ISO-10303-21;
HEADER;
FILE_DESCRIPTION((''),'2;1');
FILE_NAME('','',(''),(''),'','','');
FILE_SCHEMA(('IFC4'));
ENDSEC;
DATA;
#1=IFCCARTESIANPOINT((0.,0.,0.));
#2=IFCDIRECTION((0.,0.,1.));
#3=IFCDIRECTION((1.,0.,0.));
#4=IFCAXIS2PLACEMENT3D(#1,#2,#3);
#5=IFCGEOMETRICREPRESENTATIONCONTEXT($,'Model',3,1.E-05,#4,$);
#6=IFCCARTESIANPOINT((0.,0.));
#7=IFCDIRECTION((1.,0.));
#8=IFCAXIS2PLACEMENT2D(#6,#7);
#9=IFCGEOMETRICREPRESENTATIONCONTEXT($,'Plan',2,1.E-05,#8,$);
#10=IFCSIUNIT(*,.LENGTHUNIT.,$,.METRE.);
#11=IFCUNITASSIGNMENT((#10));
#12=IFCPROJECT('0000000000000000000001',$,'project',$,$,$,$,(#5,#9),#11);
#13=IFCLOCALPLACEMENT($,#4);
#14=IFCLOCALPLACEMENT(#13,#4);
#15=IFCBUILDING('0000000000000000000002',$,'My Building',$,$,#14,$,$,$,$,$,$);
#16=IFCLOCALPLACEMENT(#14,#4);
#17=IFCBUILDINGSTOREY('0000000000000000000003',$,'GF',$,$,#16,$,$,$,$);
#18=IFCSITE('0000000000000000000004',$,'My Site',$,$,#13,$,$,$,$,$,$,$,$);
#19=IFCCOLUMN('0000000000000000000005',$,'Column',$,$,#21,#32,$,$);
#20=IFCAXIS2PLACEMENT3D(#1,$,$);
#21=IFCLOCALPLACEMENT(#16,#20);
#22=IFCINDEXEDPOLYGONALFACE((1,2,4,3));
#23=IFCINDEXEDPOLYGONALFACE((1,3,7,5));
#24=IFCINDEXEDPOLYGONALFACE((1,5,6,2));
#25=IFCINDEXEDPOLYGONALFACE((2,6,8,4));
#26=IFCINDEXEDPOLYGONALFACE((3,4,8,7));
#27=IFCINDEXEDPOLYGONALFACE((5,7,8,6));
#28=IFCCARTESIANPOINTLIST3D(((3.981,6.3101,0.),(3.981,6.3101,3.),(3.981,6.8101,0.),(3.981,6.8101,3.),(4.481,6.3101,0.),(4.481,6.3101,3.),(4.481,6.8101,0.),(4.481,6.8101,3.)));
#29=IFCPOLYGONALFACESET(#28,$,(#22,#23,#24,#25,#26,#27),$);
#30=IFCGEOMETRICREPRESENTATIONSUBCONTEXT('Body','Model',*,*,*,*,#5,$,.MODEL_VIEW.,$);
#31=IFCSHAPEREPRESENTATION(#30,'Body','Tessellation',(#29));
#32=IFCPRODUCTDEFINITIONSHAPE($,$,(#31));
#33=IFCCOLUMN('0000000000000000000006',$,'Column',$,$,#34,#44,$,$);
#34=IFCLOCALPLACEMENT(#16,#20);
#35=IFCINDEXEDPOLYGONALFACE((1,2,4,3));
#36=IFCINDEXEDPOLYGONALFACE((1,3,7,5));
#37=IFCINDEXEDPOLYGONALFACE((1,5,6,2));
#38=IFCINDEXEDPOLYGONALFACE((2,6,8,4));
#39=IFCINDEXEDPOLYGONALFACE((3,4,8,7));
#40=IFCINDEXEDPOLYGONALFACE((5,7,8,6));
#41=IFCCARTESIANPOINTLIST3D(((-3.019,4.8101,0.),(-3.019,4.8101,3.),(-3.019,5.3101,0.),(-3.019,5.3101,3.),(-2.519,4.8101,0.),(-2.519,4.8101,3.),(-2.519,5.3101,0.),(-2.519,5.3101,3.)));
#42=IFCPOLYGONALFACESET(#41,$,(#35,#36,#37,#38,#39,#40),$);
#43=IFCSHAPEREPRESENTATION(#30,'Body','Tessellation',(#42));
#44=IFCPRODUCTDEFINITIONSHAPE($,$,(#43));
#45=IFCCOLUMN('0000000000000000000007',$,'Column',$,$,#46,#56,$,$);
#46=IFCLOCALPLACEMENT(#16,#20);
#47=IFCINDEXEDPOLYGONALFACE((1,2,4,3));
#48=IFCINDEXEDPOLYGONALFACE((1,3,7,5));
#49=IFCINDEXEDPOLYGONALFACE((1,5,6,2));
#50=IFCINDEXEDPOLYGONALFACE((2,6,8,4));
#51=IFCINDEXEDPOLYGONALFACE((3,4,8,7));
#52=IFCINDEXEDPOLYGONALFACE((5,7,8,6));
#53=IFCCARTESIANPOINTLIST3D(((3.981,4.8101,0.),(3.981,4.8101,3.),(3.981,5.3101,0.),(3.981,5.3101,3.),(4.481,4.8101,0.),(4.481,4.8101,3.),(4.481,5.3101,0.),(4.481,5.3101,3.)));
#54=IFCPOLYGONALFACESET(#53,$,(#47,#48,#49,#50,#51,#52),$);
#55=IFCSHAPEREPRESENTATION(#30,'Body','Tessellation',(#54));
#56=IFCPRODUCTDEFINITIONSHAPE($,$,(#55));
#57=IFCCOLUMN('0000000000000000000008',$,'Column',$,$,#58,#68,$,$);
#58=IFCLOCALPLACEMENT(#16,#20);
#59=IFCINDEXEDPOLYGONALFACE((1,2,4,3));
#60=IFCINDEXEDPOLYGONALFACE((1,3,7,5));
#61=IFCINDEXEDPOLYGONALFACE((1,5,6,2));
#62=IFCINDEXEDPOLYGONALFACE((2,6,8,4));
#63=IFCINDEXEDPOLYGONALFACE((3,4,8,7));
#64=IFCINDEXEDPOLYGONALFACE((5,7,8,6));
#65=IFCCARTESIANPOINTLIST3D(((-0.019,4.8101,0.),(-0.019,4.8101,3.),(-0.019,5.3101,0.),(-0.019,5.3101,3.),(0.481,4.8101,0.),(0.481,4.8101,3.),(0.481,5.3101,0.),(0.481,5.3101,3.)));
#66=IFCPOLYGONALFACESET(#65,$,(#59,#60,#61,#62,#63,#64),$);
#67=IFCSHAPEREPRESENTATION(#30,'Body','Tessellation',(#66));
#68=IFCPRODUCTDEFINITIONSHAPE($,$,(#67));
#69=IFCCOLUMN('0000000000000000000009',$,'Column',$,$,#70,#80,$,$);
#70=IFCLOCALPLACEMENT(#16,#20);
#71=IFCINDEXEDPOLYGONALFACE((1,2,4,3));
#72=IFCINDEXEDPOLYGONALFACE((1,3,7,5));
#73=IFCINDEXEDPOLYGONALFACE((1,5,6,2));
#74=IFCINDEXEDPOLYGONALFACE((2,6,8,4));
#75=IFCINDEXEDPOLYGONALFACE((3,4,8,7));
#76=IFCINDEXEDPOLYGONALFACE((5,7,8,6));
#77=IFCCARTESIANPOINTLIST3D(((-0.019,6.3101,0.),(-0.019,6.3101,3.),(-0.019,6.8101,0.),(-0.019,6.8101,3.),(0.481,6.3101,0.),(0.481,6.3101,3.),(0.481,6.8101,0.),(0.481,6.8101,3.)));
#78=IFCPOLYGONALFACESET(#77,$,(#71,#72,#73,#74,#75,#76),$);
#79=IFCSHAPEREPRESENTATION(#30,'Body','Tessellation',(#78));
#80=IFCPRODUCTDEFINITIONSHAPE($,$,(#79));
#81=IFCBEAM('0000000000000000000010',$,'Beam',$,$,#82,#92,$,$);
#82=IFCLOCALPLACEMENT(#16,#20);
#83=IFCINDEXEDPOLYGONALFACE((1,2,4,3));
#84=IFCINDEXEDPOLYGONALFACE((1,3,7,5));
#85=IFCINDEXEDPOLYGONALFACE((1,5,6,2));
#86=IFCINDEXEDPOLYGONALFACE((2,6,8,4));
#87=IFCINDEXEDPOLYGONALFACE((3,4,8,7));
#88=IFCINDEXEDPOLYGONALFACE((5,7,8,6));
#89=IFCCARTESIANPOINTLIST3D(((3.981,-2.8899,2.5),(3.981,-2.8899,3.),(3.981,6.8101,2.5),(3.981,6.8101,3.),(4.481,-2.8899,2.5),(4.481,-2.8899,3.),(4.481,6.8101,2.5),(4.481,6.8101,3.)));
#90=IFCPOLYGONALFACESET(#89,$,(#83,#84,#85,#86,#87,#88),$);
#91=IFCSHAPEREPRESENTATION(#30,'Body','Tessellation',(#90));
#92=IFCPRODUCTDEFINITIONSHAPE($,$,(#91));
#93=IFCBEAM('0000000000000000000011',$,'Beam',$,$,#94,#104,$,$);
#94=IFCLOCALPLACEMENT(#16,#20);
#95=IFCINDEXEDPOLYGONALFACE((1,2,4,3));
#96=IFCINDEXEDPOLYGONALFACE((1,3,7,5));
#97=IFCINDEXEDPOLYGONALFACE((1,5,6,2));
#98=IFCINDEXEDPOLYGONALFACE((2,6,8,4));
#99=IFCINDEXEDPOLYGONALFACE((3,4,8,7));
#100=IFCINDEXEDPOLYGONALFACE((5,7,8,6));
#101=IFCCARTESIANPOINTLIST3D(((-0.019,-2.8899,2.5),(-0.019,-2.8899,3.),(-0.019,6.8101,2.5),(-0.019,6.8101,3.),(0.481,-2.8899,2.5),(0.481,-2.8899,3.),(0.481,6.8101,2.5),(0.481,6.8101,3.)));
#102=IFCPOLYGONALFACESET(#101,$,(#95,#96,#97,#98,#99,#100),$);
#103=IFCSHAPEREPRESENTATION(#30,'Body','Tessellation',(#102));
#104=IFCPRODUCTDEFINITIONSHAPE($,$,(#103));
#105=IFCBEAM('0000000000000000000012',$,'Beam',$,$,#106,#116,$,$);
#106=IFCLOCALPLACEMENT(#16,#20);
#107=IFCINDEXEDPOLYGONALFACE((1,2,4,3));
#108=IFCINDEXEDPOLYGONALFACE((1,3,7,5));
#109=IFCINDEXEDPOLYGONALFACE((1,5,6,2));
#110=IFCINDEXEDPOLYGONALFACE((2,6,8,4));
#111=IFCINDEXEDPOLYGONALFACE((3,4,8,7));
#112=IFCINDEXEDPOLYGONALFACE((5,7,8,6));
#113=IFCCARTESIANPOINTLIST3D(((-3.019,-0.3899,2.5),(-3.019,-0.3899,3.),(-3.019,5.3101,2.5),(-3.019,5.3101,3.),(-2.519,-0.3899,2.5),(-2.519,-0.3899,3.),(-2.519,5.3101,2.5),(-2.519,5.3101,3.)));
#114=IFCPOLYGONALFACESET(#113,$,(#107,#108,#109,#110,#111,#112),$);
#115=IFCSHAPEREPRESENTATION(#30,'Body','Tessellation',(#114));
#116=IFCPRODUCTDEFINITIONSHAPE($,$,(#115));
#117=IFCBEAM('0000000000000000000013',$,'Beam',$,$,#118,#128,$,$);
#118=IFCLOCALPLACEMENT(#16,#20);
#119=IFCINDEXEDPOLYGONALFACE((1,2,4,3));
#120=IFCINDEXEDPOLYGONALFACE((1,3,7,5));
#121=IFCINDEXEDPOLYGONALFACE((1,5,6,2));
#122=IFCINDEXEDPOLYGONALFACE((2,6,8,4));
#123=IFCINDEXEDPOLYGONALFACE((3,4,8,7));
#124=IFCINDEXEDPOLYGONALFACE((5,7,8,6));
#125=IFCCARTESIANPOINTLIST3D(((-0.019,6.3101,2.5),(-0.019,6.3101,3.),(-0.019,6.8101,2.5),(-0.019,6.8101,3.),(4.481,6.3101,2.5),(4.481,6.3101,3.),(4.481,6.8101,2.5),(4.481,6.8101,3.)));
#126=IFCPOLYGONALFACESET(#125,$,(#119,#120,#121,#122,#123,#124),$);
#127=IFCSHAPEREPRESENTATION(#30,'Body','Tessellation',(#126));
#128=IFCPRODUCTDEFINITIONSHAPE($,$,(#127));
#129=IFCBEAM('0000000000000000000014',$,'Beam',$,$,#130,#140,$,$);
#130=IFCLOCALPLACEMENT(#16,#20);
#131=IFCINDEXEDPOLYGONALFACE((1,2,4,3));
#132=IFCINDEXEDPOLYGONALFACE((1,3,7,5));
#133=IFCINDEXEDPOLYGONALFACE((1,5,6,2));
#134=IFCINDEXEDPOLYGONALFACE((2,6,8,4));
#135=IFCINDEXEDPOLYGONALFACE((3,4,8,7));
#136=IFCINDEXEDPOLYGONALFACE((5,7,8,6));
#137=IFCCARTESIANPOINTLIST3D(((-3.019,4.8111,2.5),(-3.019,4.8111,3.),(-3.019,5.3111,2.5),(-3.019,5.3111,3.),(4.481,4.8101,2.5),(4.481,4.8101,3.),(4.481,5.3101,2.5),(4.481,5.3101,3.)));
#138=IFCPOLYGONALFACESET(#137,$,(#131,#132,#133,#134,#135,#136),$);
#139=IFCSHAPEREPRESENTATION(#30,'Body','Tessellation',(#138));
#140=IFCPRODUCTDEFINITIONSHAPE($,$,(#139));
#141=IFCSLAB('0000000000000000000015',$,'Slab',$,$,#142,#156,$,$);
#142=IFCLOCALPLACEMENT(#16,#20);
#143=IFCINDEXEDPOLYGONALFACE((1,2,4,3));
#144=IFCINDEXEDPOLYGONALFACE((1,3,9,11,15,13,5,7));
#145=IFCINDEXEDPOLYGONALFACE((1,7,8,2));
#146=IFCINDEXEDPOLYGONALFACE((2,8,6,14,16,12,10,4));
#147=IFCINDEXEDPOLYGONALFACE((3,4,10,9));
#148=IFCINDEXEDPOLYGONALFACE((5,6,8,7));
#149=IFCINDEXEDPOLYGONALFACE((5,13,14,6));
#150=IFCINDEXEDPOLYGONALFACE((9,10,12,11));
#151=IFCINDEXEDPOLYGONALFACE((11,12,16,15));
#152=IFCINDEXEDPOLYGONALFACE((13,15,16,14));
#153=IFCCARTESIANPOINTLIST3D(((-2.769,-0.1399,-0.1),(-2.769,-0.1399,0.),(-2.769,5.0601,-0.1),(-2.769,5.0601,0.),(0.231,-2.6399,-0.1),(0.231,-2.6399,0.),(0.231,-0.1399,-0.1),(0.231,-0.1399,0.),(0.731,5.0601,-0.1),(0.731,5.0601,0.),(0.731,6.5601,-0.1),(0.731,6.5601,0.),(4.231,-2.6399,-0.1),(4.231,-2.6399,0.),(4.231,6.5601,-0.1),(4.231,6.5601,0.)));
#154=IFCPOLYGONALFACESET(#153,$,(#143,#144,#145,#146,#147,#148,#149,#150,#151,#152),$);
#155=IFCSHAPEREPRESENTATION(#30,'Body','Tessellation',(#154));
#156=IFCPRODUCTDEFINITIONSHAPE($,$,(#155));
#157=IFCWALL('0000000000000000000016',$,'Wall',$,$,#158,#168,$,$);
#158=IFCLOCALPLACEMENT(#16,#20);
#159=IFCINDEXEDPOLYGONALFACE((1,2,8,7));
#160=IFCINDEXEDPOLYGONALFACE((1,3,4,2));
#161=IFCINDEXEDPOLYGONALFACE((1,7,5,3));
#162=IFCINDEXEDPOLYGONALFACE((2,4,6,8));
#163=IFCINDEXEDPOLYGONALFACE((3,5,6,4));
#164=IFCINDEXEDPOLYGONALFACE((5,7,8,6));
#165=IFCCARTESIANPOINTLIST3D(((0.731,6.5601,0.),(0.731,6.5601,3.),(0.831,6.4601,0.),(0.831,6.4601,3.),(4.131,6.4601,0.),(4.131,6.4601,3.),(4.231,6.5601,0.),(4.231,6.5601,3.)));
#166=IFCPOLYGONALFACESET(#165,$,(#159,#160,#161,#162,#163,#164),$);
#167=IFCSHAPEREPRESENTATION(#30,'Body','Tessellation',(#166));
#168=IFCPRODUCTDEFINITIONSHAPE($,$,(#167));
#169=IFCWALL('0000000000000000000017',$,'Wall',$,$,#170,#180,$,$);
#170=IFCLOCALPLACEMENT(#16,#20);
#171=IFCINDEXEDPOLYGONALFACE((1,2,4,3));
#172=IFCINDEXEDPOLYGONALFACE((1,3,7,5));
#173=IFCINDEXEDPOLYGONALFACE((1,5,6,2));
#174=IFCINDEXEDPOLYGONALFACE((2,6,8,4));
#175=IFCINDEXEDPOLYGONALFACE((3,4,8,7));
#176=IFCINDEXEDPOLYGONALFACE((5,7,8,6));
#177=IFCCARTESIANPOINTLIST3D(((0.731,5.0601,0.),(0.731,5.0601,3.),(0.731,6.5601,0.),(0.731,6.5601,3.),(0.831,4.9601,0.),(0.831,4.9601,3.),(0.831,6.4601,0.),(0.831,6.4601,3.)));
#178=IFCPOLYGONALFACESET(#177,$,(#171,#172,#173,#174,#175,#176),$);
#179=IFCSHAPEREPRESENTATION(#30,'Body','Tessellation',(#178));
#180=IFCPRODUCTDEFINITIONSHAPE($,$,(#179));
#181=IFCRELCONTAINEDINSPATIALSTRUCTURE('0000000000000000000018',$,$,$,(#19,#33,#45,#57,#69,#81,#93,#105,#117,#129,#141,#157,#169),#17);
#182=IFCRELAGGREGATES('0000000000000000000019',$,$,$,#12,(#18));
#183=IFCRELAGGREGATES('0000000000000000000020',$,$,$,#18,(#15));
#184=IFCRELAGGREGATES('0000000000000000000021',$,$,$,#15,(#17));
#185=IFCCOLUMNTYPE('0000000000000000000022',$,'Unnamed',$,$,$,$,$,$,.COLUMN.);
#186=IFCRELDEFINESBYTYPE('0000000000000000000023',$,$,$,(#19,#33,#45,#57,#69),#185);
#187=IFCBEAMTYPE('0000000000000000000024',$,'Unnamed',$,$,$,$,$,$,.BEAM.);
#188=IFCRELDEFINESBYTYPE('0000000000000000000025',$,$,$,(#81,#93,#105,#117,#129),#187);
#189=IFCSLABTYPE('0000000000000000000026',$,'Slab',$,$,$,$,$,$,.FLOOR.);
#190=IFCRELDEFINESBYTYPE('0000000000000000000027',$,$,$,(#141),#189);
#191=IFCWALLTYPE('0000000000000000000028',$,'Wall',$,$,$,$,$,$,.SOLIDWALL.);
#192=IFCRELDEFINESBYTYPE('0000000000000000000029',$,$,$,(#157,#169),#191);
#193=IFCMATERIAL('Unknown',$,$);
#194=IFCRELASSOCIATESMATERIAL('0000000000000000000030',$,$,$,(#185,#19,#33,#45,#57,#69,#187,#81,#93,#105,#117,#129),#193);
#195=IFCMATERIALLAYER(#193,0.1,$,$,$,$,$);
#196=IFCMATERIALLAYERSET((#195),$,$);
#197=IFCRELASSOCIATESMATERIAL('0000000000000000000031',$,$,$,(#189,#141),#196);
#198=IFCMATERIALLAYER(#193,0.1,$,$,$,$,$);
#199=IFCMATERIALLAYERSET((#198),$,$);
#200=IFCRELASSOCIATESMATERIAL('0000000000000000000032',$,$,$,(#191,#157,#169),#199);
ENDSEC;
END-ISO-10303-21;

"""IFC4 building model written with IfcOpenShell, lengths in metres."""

from ifc_helpers import new_model, si_unit, frame, origin_with_axes, origin_2d_with_axis, place, context, subcontext, project, spatial, line, indexed_curve, rectangle, outline, extrude, material, layer, layer_set, layer_usage, material_profile, profile_set, profile_usage, type_object, element, save


model = new_model("IFC4")

# Units and contexts
model_context = context("Model", 3, precision=1e-05, world=origin_with_axes())
plan_context = context("Plan", 2, precision=1e-05, world=origin_2d_with_axis())
body_context_1 = subcontext(model_context, "Body", "Model", "MODEL_VIEW")
ifc_project = project(units=[si_unit("LENGTHUNIT", "METRE")], contexts=[model_context, plan_context])

# Site, building, storey
site_placement = place(None, origin_with_axes())
site = spatial("IfcSite", under=ifc_project, at=site_placement, Name="My Site")
building_placement = place(site_placement, origin_with_axes())
building = spatial("IfcBuilding", under=site, at=building_placement, Name="My Building")
storey_placement = place(building_placement, origin_with_axes())
storey = spatial("IfcBuildingStorey", under=building, at=storey_placement, Name="GF")

# Columns
ifc_material_1 = material(Name="Unknown")
ifc_material_profile_1 = material_profile(ifc_material_1, rectangle(XDim=0.5, YDim=0.5))
ifc_profile_set_1 = profile_set([ifc_material_profile_1])
ifc_profile_usage_1 = profile_usage(ifc_profile_set_1, cardinal=5)
column_type = type_object("IfcColumnType", Name="Unnamed", PredefinedType="COLUMN", material=ifc_profile_set_1)
column_1_placement = place(storey_placement, frame((4.231, 6.5601, 0.0), z_axis=(0.0, 0.0, 1.0), x_axis=(1.0, 0.0, 0.0)))
element("IfcColumn", 1, at=column_1_placement, inside=storey, type_object=column_type, material=ifc_profile_usage_1, Name="Column", context=body_context_1, shape_type="SweptSolid", body=[
    extrude(rectangle(XDim=0.5, YDim=0.5), origin_with_axes(), (0.0, 0.0, 1.0), 3.0),
])
ifc_profile_usage_2 = profile_usage(ifc_profile_set_1, cardinal=5)
column_2_placement = place(storey_placement, frame((-2.769, 5.0601, 0.0), z_axis=(0.0, 0.0, 1.0), x_axis=(1.0, 0.0, 0.0)))
element("IfcColumn", 2, at=column_2_placement, inside=storey, type_object=column_type, material=ifc_profile_usage_2, Name="Column", context=body_context_1, shape_type="SweptSolid", body=[
    extrude(rectangle(XDim=0.5, YDim=0.5), origin_with_axes(), (0.0, 0.0, 1.0), 3.0),
])
ifc_profile_usage_3 = profile_usage(ifc_profile_set_1, cardinal=5)
column_3_placement = place(storey_placement, frame((4.231, 5.0601, 0.0), z_axis=(0.0, 0.0, 1.0), x_axis=(1.0, 0.0, 0.0)))
element("IfcColumn", 3, at=column_3_placement, inside=storey, type_object=column_type, material=ifc_profile_usage_3, Name="Column", context=body_context_1, shape_type="SweptSolid", body=[
    extrude(rectangle(XDim=0.5, YDim=0.5), origin_with_axes(), (0.0, 0.0, 1.0), 3.0),
])
ifc_profile_usage_4 = profile_usage(ifc_profile_set_1, cardinal=5)
column_4_placement = place(storey_placement, frame((0.231, 5.0601, 0.0), z_axis=(0.0, 0.0, 1.0), x_axis=(1.0, 0.0, 0.0)))
element("IfcColumn", 4, at=column_4_placement, inside=storey, type_object=column_type, material=ifc_profile_usage_4, Name="Column", context=body_context_1, shape_type="SweptSolid", body=[
    extrude(rectangle(XDim=0.5, YDim=0.5), origin_with_axes(), (0.0, 0.0, 1.0), 3.0),
])
ifc_profile_usage_5 = profile_usage(ifc_profile_set_1, cardinal=5)
column_5_placement = place(storey_placement, frame((0.231, 6.5601, 0.0), z_axis=(0.0, 0.0, 1.0), x_axis=(1.0, 0.0, 0.0)))
element("IfcColumn", 5, at=column_5_placement, inside=storey, type_object=column_type, material=ifc_profile_usage_5, Name="Column", context=body_context_1, shape_type="SweptSolid", body=[
    extrude(rectangle(XDim=0.5, YDim=0.5), origin_with_axes(), (0.0, 0.0, 1.0), 3.0),
])

# Beams
ifc_material_profile_2 = material_profile(ifc_material_1, rectangle(XDim=0.5, YDim=0.5))
ifc_profile_set_2 = profile_set([ifc_material_profile_2])
ifc_profile_usage_6 = profile_usage(ifc_profile_set_2, cardinal=7)
beam_type = type_object("IfcBeamType", Name="Unnamed", PredefinedType="BEAM", material=ifc_profile_set_2)
beam_1_placement = place(storey_placement, frame((4.481, 6.8101, 3.0), z_axis=(0.0, -1.0, 0.0), x_axis=(1.0, 0.0, 0.0)))
element("IfcBeam", 6, at=beam_1_placement, inside=storey, type_object=beam_type, material=ifc_profile_usage_6, Name="Beam", context=body_context_1, shape_type="SweptSolid", body=[
    extrude(rectangle(XDim=0.5, YDim=0.5), frame((-0.25, -0.25, 0.0), z_axis=(0.0, 0.0, 1.0), x_axis=(1.0, 0.0, 0.0)), (0.0, 0.0, 1.0), 9.7),
])
ifc_profile_usage_7 = profile_usage(ifc_profile_set_2, cardinal=7)
beam_2_placement = place(storey_placement, frame((0.481, 6.8101, 3.0), z_axis=(0.0, -1.0, 0.0), x_axis=(1.0, 0.0, 0.0)))
element("IfcBeam", 7, at=beam_2_placement, inside=storey, type_object=beam_type, material=ifc_profile_usage_7, Name="Beam", context=body_context_1, shape_type="SweptSolid", body=[
    extrude(rectangle(XDim=0.5, YDim=0.5), frame((-0.25, -0.25, 0.0), z_axis=(0.0, 0.0, 1.0), x_axis=(1.0, 0.0, 0.0)), (0.0, 0.0, 1.0), 9.7),
])
ifc_profile_usage_8 = profile_usage(ifc_profile_set_2, cardinal=7)
beam_3_placement = place(storey_placement, frame((-2.519, 5.3101, 3.0), z_axis=(0.0, -1.0, 0.0), x_axis=(1.0, 0.0, 0.0)))
element("IfcBeam", 8, at=beam_3_placement, inside=storey, type_object=beam_type, material=ifc_profile_usage_8, Name="Beam", context=body_context_1, shape_type="SweptSolid", body=[
    extrude(rectangle(XDim=0.5, YDim=0.5), frame((-0.25, -0.25, 0.0), z_axis=(0.0, 0.0, 1.0), x_axis=(1.0, 0.0, 0.0)), (0.0, 0.0, 1.0), 5.7),
])
ifc_profile_usage_9 = profile_usage(ifc_profile_set_2, cardinal=7)
beam_4_placement = place(storey_placement, frame((4.481, 6.3101, 3.0), z_axis=(-1.0, -0.000001, 0.000001), x_axis=(0.000001, -1.0, 0.0)))
element("IfcBeam", 9, at=beam_4_placement, inside=storey, type_object=beam_type, material=ifc_profile_usage_9, Name="Beam", context=body_context_1, shape_type="SweptSolid", body=[
    extrude(rectangle(XDim=0.5, YDim=0.5), frame((-0.25, -0.25, 0.0), z_axis=(0.0, 0.0, 1.0), x_axis=(1.0, 0.0, 0.0)), (0.0, 0.0, 1.0), 4.5),
])
ifc_profile_usage_10 = profile_usage(ifc_profile_set_2, cardinal=7)
beam_5_placement = place(storey_placement, frame((4.481, 4.8101, 3.0), z_axis=(-1.0, 0.000129, 0.0), x_axis=(-0.000129, -1.0, 0.0)))
element("IfcBeam", 10, at=beam_5_placement, inside=storey, type_object=beam_type, material=ifc_profile_usage_10, Name="Beam", context=body_context_1, shape_type="SweptSolid", body=[
    extrude(rectangle(XDim=0.5, YDim=0.5), frame((-0.25, -0.25, 0.0), z_axis=(0.0, 0.0, 1.0), x_axis=(1.0, 0.0, 0.0)), (0.0, 0.0, 1.0), 7.5),
])

# Slab
ifc_layer_1 = layer(ifc_material_1, 0.1)
ifc_layer_set_1 = layer_set([ifc_layer_1])
ifc_layer_usage_1 = layer_usage(ifc_layer_set_1, "AXIS3", "POSITIVE", -0.1)
slab_type = type_object("IfcSlabType", Name="Slab", PredefinedType="FLOOR", material=ifc_layer_set_1)
slab_placement = place(storey_placement, frame((4.231, 6.5601, 0.0), z_axis=(0.0, 0.0, 1.0), x_axis=(1.0, 0.0, 0.0)))
element("IfcSlab", 11, at=slab_placement, inside=storey, type_object=slab_type, material=ifc_layer_usage_1, Name="Slab", context=body_context_1, shape_type="SweptSolid", body=[
    extrude(outline(indexed_curve([(0.0, 0.0), (-3.5, 0.0), (-3.5, -1.5), (-7.0, -1.5), (-7.0, -6.7), (-4.0, -6.7), (-4.0, -9.2), (0.0, -9.2), (0.0, 0.0)])), frame((0.0, 0.0, -0.1), z_axis=(0.0, 0.0, 1.0), x_axis=(1.0, 0.0, 0.0)), (0.0, 0.0, 1.0), 0.1),
])

# Walls
ifc_layer_2 = layer(ifc_material_1, 0.1)
ifc_layer_set_2 = layer_set([ifc_layer_2])
ifc_layer_usage_2 = layer_usage(ifc_layer_set_2, "AXIS2", "POSITIVE", 0.0)
wall_type = type_object("IfcWallType", Name="Wall", PredefinedType="SOLIDWALL", material=ifc_layer_set_2)
wall_1_placement = place(storey_placement, frame((4.231, 6.5601, 0.0), z_axis=(0.0, 0.0, 1.0), x_axis=(-1.0, 0.0, 0.0)))
element("IfcWall", 12, at=wall_1_placement, inside=storey, type_object=wall_type, material=ifc_layer_usage_2, Name="Wall", context=body_context_1, shape_type="SweptSolid", body=[
    extrude(outline(indexed_curve([(0.0, 0.0), (0.1, 0.1), (3.4, 0.1), (3.5, 0.0)], segments=[line(1, 2, 3, 4, 1)])), origin_with_axes(), (0.0, 0.0, 1.0), 3.0),
])
ifc_layer_usage_3 = layer_usage(ifc_layer_set_2, "AXIS2", "POSITIVE", 0.0)
wall_2_placement = place(storey_placement, frame((0.731, 6.5601, 0.0), z_axis=(0.0, 0.0, 1.0), x_axis=(0.0, -1.0, 0.0)))
element("IfcWall", 13, at=wall_2_placement, inside=storey, type_object=wall_type, material=ifc_layer_usage_3, Name="Wall", context=body_context_1, shape_type="SweptSolid", body=[
    extrude(outline(indexed_curve([(0.0, 0.0), (0.1, 0.1), (1.6, 0.1), (1.5, 0.0)], segments=[line(1, 2, 3, 4, 1)])), origin_with_axes(), (0.0, 0.0, 1.0), 3.0),
])

save(model, "model.ifc")
